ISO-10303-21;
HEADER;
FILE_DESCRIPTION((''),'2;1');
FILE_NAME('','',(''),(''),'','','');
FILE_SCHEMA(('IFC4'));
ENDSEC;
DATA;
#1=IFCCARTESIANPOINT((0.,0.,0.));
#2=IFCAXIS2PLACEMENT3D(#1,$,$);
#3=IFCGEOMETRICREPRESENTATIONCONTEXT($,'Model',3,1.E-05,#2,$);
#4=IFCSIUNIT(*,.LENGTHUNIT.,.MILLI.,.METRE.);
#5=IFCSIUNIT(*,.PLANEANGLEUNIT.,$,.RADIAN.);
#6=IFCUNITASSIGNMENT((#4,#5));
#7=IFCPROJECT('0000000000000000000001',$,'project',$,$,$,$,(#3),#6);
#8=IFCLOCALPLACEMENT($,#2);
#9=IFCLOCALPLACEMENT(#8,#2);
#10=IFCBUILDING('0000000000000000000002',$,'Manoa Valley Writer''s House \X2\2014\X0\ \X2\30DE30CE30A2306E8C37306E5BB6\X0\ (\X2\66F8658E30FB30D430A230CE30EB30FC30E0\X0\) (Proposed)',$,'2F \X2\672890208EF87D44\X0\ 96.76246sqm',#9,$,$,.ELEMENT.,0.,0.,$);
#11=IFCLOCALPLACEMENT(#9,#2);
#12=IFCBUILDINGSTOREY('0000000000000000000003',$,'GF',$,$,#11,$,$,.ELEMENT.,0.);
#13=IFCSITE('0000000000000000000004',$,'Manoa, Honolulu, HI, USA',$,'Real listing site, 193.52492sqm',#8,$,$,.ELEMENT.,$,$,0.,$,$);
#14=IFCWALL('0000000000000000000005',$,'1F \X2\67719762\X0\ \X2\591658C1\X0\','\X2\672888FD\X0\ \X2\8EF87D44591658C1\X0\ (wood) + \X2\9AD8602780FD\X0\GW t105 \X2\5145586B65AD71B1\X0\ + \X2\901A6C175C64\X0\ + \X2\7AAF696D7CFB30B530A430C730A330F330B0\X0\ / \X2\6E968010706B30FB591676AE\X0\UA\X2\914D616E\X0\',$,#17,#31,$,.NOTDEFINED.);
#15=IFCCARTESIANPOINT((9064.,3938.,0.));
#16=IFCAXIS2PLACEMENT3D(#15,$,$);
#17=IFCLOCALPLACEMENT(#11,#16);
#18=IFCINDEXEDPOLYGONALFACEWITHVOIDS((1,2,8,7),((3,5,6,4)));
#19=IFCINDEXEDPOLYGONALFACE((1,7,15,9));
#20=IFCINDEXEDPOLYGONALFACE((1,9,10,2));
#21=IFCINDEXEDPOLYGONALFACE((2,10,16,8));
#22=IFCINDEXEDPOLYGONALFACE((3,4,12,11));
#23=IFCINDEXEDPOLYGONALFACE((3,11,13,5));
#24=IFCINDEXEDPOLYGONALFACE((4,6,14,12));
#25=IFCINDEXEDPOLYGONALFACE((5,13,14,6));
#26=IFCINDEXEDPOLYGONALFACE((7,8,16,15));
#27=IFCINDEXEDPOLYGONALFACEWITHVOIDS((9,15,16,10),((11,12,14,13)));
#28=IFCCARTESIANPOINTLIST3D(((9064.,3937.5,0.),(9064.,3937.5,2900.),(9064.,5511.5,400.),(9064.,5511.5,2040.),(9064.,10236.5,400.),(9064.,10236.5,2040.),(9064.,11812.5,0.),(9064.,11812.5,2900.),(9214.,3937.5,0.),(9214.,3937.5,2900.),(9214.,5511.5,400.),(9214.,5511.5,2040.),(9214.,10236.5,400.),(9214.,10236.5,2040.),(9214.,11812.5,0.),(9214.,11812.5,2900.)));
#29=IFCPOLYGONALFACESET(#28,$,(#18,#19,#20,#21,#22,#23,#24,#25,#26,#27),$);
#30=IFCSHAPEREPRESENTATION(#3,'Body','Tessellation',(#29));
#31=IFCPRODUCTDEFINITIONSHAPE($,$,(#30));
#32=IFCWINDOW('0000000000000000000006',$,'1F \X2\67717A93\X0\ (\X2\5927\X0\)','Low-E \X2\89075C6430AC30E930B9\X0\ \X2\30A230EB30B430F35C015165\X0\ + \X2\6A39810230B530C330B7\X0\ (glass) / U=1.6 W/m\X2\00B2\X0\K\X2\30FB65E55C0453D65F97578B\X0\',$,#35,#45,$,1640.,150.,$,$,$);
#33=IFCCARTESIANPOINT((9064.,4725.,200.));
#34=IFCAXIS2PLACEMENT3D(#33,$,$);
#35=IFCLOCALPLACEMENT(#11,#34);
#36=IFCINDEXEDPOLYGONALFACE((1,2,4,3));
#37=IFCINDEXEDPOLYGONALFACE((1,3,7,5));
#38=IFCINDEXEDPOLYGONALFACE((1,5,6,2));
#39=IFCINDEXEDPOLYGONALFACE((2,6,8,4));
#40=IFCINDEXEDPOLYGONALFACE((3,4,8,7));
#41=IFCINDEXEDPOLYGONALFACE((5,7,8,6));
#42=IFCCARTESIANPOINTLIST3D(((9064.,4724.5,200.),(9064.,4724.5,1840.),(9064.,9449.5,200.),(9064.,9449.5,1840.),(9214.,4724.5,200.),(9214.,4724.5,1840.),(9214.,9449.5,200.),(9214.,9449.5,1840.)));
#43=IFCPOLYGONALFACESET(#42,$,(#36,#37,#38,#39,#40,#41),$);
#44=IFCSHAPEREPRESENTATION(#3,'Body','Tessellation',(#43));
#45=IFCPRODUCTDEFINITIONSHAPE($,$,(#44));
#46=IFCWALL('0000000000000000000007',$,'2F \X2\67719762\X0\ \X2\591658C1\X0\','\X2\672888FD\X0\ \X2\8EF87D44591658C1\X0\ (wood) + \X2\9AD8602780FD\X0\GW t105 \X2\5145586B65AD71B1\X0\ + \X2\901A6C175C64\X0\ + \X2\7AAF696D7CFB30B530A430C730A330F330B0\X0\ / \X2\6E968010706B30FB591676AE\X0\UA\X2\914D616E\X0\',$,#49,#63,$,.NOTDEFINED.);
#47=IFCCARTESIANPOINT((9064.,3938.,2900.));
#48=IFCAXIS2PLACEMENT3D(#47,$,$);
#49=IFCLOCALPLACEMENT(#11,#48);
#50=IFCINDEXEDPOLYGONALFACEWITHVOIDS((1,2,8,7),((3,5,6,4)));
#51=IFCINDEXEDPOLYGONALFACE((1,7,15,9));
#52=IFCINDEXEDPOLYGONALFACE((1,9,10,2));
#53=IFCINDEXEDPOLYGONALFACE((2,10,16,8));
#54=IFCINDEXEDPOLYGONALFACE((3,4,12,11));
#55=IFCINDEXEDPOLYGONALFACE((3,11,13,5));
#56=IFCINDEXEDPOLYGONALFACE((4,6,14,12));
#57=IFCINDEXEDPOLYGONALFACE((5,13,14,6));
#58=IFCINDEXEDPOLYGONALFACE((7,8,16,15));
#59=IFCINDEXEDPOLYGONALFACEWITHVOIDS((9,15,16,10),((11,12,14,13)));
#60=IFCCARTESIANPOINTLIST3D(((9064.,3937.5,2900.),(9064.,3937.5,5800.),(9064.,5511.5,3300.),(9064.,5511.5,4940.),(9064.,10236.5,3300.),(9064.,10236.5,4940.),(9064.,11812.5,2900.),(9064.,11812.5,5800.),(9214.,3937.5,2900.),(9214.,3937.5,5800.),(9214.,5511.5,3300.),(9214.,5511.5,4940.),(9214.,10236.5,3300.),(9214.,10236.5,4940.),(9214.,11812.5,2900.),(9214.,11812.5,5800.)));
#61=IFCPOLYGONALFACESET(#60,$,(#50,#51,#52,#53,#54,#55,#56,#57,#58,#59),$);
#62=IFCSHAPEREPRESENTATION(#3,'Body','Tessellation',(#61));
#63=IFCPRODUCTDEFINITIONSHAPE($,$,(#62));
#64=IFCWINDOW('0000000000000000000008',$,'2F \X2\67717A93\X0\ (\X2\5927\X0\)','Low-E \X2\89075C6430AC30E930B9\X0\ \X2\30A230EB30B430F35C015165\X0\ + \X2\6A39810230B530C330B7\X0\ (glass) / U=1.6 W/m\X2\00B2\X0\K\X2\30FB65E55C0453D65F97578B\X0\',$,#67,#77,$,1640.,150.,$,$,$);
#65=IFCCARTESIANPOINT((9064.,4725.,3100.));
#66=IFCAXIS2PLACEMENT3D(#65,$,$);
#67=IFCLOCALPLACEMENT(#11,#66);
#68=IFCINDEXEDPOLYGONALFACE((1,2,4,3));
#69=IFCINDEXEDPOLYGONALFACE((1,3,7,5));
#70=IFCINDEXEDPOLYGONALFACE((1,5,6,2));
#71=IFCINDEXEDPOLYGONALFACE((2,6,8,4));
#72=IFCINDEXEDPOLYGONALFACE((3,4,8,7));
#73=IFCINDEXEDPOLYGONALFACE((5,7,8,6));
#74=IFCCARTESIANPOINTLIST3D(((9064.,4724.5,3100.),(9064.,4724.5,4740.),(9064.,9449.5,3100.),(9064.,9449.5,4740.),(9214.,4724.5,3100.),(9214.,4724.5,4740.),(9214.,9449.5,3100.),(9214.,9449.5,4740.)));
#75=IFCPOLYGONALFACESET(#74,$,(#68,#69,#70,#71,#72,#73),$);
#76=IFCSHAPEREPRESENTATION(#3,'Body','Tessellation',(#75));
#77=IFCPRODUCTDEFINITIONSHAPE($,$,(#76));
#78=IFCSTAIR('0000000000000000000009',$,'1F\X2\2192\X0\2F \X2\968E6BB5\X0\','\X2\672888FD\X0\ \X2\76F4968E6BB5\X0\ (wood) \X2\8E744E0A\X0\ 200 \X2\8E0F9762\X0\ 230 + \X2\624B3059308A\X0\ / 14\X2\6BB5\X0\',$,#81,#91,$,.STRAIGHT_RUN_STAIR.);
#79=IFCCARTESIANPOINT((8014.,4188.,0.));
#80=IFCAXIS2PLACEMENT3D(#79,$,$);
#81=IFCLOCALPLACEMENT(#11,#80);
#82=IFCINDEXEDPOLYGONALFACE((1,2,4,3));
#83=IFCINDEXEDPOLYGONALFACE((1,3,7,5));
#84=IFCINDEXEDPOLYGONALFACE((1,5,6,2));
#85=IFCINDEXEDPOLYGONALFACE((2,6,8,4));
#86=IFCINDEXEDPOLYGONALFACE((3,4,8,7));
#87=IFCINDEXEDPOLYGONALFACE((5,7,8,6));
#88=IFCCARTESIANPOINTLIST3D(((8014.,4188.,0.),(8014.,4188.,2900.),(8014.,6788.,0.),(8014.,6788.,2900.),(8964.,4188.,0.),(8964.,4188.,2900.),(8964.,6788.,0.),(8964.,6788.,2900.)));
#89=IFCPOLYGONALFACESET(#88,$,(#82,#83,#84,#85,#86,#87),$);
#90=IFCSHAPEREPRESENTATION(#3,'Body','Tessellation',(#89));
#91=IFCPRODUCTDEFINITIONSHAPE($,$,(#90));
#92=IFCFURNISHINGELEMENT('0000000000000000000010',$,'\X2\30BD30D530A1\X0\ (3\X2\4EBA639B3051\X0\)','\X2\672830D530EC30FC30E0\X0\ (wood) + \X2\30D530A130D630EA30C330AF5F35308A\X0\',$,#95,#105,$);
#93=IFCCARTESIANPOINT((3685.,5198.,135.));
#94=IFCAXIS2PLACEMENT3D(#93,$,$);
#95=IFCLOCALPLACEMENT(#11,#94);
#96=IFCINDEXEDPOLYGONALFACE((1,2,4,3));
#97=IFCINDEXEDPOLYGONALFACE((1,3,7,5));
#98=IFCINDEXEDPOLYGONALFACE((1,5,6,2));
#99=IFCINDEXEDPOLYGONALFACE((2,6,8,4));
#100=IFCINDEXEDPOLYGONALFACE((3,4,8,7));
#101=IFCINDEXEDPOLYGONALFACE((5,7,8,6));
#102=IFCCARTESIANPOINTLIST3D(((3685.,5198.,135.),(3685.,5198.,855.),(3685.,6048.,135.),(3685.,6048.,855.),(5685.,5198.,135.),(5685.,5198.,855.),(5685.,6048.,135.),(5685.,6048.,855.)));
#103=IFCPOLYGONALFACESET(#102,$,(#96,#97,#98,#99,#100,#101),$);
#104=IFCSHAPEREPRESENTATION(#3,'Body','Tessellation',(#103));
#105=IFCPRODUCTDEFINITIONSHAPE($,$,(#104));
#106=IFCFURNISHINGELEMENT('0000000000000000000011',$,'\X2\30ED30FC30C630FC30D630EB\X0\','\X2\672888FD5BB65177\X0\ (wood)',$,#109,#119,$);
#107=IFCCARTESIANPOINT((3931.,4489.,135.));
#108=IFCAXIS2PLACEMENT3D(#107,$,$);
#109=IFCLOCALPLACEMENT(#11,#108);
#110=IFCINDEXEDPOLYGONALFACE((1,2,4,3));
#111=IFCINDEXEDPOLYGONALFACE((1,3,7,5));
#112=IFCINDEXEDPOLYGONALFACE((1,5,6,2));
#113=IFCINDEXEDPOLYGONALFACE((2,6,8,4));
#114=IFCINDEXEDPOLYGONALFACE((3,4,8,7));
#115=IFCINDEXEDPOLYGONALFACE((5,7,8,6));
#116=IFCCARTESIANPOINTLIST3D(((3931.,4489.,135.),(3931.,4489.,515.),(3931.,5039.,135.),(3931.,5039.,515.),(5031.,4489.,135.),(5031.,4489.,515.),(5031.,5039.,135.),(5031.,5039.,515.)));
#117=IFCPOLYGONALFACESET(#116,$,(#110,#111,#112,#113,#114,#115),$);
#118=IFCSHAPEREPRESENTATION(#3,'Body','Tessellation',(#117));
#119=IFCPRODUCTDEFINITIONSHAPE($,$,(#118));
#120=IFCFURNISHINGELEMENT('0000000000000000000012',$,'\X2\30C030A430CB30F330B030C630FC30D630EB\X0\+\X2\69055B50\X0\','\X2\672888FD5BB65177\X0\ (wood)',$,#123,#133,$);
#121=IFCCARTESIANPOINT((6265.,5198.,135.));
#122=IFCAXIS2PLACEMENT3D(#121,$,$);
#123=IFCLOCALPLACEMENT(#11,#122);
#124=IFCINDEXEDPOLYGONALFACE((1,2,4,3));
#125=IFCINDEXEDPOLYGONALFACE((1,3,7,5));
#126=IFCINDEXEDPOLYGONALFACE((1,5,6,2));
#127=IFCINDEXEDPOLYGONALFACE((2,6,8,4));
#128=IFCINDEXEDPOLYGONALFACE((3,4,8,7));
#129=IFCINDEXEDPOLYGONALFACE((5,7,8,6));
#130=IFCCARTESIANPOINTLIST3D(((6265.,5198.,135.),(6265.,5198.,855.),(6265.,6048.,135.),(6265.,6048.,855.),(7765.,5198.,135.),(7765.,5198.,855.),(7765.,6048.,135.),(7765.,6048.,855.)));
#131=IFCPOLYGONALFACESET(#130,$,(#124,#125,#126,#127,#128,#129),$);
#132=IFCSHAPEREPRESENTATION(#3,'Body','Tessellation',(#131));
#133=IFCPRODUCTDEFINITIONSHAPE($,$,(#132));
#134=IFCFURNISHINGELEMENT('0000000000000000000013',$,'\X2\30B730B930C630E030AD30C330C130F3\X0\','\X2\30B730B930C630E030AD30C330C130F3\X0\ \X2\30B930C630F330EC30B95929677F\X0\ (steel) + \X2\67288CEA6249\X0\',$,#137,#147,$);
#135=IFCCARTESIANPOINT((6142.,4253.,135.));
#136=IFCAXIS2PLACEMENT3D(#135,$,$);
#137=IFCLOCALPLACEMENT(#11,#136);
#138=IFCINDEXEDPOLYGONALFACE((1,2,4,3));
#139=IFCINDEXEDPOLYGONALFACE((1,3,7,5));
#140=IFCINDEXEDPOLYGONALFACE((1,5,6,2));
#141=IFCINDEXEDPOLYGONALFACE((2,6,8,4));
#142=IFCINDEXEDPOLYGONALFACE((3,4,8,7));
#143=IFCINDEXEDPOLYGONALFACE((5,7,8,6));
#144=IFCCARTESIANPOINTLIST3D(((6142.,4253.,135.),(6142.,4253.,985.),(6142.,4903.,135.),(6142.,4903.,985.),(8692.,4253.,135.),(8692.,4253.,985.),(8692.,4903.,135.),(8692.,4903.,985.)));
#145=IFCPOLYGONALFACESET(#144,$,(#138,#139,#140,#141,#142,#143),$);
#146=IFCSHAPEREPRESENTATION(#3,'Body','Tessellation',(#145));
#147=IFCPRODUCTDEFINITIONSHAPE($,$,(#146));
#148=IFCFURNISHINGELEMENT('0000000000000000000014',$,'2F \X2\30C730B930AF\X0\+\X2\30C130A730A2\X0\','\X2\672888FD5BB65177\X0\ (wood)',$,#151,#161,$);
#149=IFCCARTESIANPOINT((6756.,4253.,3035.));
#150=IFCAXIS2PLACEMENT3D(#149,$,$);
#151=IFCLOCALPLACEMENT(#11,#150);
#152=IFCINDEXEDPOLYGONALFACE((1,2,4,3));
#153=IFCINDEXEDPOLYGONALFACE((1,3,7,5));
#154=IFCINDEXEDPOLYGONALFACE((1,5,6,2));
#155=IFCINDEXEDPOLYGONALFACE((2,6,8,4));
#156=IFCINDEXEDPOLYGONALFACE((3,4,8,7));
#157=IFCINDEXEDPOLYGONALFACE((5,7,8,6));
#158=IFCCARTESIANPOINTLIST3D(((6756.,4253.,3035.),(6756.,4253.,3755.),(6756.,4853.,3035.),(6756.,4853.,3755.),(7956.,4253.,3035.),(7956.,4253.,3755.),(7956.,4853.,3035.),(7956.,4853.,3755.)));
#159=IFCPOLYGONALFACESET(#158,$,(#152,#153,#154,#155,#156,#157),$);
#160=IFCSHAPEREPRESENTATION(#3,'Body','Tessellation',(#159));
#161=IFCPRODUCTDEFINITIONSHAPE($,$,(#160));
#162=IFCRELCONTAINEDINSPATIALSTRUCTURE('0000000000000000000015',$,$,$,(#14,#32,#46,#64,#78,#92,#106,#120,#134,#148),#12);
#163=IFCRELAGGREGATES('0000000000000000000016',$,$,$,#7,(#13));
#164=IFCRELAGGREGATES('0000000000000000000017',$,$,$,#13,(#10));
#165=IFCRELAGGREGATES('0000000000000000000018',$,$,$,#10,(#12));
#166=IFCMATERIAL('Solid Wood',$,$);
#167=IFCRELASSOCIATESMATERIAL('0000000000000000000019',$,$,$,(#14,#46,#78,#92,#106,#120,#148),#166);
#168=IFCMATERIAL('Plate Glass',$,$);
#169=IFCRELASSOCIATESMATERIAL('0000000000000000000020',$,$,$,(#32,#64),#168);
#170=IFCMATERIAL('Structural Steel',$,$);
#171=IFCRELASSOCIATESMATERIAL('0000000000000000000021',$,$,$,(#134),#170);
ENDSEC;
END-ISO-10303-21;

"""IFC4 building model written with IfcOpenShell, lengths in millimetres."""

from ifc_helpers import new_model, si_unit, frame, frame_2d, origin, place, context, project, spatial, rectangle, extrude, material, element, fill, save


model = new_model("IFC4")

# Units and contexts
model_context = context("Model", 3, precision=1e-05, world=origin())
ifc_project = project(units=[si_unit("LENGTHUNIT", "METRE", prefix="MILLI"), si_unit("PLANEANGLEUNIT", "RADIAN")], contexts=[model_context])

# Site, building, storey
site_placement = place(None, origin())
site = spatial("IfcSite", under=ifc_project, at=site_placement, Name="Manoa, Honolulu, HI, USA", ObjectType="Real listing site, 193.52492sqm", CompositionType="ELEMENT", RefElevation=0.0)
building_placement = place(site_placement, origin())
building = spatial("IfcBuilding", under=site, at=building_placement, Name="Manoa Valley Writer's House — マノアの谷の家 (書斎・ピアノルーム) (Proposed)", ObjectType="2F 木造軸組 96.76246sqm", CompositionType="ELEMENT", ElevationOfRefHeight=0.0, ElevationOfTerrain=0.0)
storey_placement = place(building_placement, origin())
storey = spatial("IfcBuildingStorey", under=building, at=storey_placement, Name="GF", CompositionType="ELEMENT", Elevation=0.0)

# Wall, opening, window
ifc_material_1 = material(Name="Solid Wood")
wall_1_placement = place(storey_placement, frame((9064.0, 3938.0, 0.0)))
wall_1 = element("IfcWall", 1, at=wall_1_placement, inside=storey, material=ifc_material_1, Name="1F 東面 外壁", Description="木製 軸組外壁 (wood) + 高性能GW t105 充填断熱 + 通気層 + 窯業系サイディング / 準耐火・外皮UA配慮", PredefinedType="NOTDEFINED", context=model_context, shape_type="SweptSolid", body=[
    extrude(rectangle(XDim=150.0, YDim=7875.0, at=frame_2d((75.0, 3937.0))), frame((9064.0, 3938.0, 0.0)), (0.0, 0.0, 1.0), 2900.0),
])
opening_1_placement = place(storey_placement, frame((9064.0, 4725.0, 200.0)))
opening_1 = element("IfcOpeningElement", 2, at=opening_1_placement, cuts=wall_1, PredefinedType="NOTDEFINED", context=model_context, shape_type="SweptSolid", body=[
    extrude(rectangle(XDim=150.0, YDim=4725.0, at=frame_2d((75.0, 2362.0))), frame((9064.0, 4725.0, 200.0)), (0.0, 0.0, 1.0), 1640.0),
])
ifc_material_2 = material(Name="Plate Glass")
window_1_placement = place(storey_placement, frame((9064.0, 4725.0, 200.0)))
window_1 = element("IfcWindow", 3, at=window_1_placement, inside=storey, material=ifc_material_2, Name="1F 東窓 (大)", Description="Low-E 複層ガラス アルゴン封入 + 樹脂サッシ (glass) / U=1.6 W/m²K・日射取得型", OverallHeight=1640.0, OverallWidth=150.0, context=model_context, shape_type="SweptSolid", body=[
    extrude(rectangle(XDim=150.0, YDim=4725.0, at=frame_2d((75.0, 2362.0))), frame((9064.0, 4725.0, 200.0)), (0.0, 0.0, 1.0), 1640.0),
])
fill(opening_1, window_1)

# Wall, opening, window
wall_2_placement = place(storey_placement, frame((9064.0, 3938.0, 2900.0)))
wall_2 = element("IfcWall", 4, at=wall_2_placement, inside=storey, material=ifc_material_1, Name="2F 東面 外壁", Description="木製 軸組外壁 (wood) + 高性能GW t105 充填断熱 + 通気層 + 窯業系サイディング / 準耐火・外皮UA配慮", PredefinedType="NOTDEFINED", context=model_context, shape_type="SweptSolid", body=[
    extrude(rectangle(XDim=150.0, YDim=7875.0, at=frame_2d((75.0, 3937.0))), frame((9064.0, 3938.0, 2900.0)), (0.0, 0.0, 1.0), 2900.0),
])
opening_2_placement = place(storey_placement, frame((9064.0, 4725.0, 3100.0)))
opening_2 = element("IfcOpeningElement", 5, at=opening_2_placement, cuts=wall_2, PredefinedType="NOTDEFINED", context=model_context, shape_type="SweptSolid", body=[
    extrude(rectangle(XDim=150.0, YDim=4725.0, at=frame_2d((75.0, 2362.0))), frame((9064.0, 4725.0, 3100.0)), (0.0, 0.0, 1.0), 1640.0),
])
window_2_placement = place(storey_placement, frame((9064.0, 4725.0, 3100.0)))
window_2 = element("IfcWindow", 6, at=window_2_placement, inside=storey, material=ifc_material_2, Name="2F 東窓 (大)", Description="Low-E 複層ガラス アルゴン封入 + 樹脂サッシ (glass) / U=1.6 W/m²K・日射取得型", OverallHeight=1640.0, OverallWidth=150.0, context=model_context, shape_type="SweptSolid", body=[
    extrude(rectangle(XDim=150.0, YDim=4725.0, at=frame_2d((75.0, 2362.0))), frame((9064.0, 4725.0, 3100.0)), (0.0, 0.0, 1.0), 1640.0),
])
fill(opening_2, window_2)

# Stair
stair_placement = place(storey_placement, frame((8014.0, 4188.0, 0.0)))
element("IfcStair", 7, at=stair_placement, inside=storey, material=ifc_material_1, Name="1F→2F 階段", Description="木製 直階段 (wood) 蹴上 200 踏面 230 + 手すり / 14段", PredefinedType="STRAIGHT_RUN_STAIR", context=model_context, shape_type="SweptSolid", body=[
    extrude(rectangle(XDim=950.0, YDim=2600.0, at=frame_2d((475.0, 1300.0))), frame((8014.0, 4188.0, 0.0)), (0.0, 0.0, 1.0), 2900.0),
])

# Furnishing elements
furnishing_1_placement = place(storey_placement, frame((3685.0, 5198.0, 135.0)))
element("IfcFurnishingElement", 8, at=furnishing_1_placement, inside=storey, material=ifc_material_1, Name="ソファ (3人掛け)", Description="木フレーム (wood) + ファブリック張り", context=model_context, shape_type="SweptSolid", body=[
    extrude(rectangle(XDim=2000.0, YDim=850.0, at=frame_2d((1000.0, 425.0))), frame((3685.0, 5198.0, 135.0)), (0.0, 0.0, 1.0), 720.0),
])
furnishing_2_placement = place(storey_placement, frame((3931.0, 4489.0, 135.0)))
element("IfcFurnishingElement", 9, at=furnishing_2_placement, inside=storey, material=ifc_material_1, Name="ローテーブル", Description="木製家具 (wood)", context=model_context, shape_type="SweptSolid", body=[
    extrude(rectangle(XDim=1100.0, YDim=550.0, at=frame_2d((550.0, 275.0))), frame((3931.0, 4489.0, 135.0)), (0.0, 0.0, 1.0), 380.0),
])
furnishing_3_placement = place(storey_placement, frame((6265.0, 5198.0, 135.0)))
element("IfcFurnishingElement", 10, at=furnishing_3_placement, inside=storey, material=ifc_material_1, Name="ダイニングテーブル+椅子", Description="木製家具 (wood)", context=model_context, shape_type="SweptSolid", body=[
    extrude(rectangle(XDim=1500.0, YDim=850.0, at=frame_2d((750.0, 425.0))), frame((6265.0, 5198.0, 135.0)), (0.0, 0.0, 1.0), 720.0),
])
ifc_material_3 = material(Name="Structural Steel")
furnishing_4_placement = place(storey_placement, frame((6142.0, 4253.0, 135.0)))
element("IfcFurnishingElement", 11, at=furnishing_4_placement, inside=storey, material=ifc_material_3, Name="システムキッチン", Description="システムキッチン ステンレス天板 (steel) + 木質扉", context=model_context, shape_type="SweptSolid", body=[
    extrude(rectangle(XDim=2550.0, YDim=650.0, at=frame_2d((1275.0, 325.0))), frame((6142.0, 4253.0, 135.0)), (0.0, 0.0, 1.0), 850.0),
])
furnishing_5_placement = place(storey_placement, frame((6756.0, 4253.0, 3035.0)))
element("IfcFurnishingElement", 12, at=furnishing_5_placement, inside=storey, material=ifc_material_1, Name="2F デスク+チェア", Description="木製家具 (wood)", context=model_context, shape_type="SweptSolid", body=[
    extrude(rectangle(XDim=1200.0, YDim=600.0, at=frame_2d((600.0, 300.0))), frame((6756.0, 4253.0, 3035.0)), (0.0, 0.0, 1.0), 720.0),
])

save(model, "model.ifc")
